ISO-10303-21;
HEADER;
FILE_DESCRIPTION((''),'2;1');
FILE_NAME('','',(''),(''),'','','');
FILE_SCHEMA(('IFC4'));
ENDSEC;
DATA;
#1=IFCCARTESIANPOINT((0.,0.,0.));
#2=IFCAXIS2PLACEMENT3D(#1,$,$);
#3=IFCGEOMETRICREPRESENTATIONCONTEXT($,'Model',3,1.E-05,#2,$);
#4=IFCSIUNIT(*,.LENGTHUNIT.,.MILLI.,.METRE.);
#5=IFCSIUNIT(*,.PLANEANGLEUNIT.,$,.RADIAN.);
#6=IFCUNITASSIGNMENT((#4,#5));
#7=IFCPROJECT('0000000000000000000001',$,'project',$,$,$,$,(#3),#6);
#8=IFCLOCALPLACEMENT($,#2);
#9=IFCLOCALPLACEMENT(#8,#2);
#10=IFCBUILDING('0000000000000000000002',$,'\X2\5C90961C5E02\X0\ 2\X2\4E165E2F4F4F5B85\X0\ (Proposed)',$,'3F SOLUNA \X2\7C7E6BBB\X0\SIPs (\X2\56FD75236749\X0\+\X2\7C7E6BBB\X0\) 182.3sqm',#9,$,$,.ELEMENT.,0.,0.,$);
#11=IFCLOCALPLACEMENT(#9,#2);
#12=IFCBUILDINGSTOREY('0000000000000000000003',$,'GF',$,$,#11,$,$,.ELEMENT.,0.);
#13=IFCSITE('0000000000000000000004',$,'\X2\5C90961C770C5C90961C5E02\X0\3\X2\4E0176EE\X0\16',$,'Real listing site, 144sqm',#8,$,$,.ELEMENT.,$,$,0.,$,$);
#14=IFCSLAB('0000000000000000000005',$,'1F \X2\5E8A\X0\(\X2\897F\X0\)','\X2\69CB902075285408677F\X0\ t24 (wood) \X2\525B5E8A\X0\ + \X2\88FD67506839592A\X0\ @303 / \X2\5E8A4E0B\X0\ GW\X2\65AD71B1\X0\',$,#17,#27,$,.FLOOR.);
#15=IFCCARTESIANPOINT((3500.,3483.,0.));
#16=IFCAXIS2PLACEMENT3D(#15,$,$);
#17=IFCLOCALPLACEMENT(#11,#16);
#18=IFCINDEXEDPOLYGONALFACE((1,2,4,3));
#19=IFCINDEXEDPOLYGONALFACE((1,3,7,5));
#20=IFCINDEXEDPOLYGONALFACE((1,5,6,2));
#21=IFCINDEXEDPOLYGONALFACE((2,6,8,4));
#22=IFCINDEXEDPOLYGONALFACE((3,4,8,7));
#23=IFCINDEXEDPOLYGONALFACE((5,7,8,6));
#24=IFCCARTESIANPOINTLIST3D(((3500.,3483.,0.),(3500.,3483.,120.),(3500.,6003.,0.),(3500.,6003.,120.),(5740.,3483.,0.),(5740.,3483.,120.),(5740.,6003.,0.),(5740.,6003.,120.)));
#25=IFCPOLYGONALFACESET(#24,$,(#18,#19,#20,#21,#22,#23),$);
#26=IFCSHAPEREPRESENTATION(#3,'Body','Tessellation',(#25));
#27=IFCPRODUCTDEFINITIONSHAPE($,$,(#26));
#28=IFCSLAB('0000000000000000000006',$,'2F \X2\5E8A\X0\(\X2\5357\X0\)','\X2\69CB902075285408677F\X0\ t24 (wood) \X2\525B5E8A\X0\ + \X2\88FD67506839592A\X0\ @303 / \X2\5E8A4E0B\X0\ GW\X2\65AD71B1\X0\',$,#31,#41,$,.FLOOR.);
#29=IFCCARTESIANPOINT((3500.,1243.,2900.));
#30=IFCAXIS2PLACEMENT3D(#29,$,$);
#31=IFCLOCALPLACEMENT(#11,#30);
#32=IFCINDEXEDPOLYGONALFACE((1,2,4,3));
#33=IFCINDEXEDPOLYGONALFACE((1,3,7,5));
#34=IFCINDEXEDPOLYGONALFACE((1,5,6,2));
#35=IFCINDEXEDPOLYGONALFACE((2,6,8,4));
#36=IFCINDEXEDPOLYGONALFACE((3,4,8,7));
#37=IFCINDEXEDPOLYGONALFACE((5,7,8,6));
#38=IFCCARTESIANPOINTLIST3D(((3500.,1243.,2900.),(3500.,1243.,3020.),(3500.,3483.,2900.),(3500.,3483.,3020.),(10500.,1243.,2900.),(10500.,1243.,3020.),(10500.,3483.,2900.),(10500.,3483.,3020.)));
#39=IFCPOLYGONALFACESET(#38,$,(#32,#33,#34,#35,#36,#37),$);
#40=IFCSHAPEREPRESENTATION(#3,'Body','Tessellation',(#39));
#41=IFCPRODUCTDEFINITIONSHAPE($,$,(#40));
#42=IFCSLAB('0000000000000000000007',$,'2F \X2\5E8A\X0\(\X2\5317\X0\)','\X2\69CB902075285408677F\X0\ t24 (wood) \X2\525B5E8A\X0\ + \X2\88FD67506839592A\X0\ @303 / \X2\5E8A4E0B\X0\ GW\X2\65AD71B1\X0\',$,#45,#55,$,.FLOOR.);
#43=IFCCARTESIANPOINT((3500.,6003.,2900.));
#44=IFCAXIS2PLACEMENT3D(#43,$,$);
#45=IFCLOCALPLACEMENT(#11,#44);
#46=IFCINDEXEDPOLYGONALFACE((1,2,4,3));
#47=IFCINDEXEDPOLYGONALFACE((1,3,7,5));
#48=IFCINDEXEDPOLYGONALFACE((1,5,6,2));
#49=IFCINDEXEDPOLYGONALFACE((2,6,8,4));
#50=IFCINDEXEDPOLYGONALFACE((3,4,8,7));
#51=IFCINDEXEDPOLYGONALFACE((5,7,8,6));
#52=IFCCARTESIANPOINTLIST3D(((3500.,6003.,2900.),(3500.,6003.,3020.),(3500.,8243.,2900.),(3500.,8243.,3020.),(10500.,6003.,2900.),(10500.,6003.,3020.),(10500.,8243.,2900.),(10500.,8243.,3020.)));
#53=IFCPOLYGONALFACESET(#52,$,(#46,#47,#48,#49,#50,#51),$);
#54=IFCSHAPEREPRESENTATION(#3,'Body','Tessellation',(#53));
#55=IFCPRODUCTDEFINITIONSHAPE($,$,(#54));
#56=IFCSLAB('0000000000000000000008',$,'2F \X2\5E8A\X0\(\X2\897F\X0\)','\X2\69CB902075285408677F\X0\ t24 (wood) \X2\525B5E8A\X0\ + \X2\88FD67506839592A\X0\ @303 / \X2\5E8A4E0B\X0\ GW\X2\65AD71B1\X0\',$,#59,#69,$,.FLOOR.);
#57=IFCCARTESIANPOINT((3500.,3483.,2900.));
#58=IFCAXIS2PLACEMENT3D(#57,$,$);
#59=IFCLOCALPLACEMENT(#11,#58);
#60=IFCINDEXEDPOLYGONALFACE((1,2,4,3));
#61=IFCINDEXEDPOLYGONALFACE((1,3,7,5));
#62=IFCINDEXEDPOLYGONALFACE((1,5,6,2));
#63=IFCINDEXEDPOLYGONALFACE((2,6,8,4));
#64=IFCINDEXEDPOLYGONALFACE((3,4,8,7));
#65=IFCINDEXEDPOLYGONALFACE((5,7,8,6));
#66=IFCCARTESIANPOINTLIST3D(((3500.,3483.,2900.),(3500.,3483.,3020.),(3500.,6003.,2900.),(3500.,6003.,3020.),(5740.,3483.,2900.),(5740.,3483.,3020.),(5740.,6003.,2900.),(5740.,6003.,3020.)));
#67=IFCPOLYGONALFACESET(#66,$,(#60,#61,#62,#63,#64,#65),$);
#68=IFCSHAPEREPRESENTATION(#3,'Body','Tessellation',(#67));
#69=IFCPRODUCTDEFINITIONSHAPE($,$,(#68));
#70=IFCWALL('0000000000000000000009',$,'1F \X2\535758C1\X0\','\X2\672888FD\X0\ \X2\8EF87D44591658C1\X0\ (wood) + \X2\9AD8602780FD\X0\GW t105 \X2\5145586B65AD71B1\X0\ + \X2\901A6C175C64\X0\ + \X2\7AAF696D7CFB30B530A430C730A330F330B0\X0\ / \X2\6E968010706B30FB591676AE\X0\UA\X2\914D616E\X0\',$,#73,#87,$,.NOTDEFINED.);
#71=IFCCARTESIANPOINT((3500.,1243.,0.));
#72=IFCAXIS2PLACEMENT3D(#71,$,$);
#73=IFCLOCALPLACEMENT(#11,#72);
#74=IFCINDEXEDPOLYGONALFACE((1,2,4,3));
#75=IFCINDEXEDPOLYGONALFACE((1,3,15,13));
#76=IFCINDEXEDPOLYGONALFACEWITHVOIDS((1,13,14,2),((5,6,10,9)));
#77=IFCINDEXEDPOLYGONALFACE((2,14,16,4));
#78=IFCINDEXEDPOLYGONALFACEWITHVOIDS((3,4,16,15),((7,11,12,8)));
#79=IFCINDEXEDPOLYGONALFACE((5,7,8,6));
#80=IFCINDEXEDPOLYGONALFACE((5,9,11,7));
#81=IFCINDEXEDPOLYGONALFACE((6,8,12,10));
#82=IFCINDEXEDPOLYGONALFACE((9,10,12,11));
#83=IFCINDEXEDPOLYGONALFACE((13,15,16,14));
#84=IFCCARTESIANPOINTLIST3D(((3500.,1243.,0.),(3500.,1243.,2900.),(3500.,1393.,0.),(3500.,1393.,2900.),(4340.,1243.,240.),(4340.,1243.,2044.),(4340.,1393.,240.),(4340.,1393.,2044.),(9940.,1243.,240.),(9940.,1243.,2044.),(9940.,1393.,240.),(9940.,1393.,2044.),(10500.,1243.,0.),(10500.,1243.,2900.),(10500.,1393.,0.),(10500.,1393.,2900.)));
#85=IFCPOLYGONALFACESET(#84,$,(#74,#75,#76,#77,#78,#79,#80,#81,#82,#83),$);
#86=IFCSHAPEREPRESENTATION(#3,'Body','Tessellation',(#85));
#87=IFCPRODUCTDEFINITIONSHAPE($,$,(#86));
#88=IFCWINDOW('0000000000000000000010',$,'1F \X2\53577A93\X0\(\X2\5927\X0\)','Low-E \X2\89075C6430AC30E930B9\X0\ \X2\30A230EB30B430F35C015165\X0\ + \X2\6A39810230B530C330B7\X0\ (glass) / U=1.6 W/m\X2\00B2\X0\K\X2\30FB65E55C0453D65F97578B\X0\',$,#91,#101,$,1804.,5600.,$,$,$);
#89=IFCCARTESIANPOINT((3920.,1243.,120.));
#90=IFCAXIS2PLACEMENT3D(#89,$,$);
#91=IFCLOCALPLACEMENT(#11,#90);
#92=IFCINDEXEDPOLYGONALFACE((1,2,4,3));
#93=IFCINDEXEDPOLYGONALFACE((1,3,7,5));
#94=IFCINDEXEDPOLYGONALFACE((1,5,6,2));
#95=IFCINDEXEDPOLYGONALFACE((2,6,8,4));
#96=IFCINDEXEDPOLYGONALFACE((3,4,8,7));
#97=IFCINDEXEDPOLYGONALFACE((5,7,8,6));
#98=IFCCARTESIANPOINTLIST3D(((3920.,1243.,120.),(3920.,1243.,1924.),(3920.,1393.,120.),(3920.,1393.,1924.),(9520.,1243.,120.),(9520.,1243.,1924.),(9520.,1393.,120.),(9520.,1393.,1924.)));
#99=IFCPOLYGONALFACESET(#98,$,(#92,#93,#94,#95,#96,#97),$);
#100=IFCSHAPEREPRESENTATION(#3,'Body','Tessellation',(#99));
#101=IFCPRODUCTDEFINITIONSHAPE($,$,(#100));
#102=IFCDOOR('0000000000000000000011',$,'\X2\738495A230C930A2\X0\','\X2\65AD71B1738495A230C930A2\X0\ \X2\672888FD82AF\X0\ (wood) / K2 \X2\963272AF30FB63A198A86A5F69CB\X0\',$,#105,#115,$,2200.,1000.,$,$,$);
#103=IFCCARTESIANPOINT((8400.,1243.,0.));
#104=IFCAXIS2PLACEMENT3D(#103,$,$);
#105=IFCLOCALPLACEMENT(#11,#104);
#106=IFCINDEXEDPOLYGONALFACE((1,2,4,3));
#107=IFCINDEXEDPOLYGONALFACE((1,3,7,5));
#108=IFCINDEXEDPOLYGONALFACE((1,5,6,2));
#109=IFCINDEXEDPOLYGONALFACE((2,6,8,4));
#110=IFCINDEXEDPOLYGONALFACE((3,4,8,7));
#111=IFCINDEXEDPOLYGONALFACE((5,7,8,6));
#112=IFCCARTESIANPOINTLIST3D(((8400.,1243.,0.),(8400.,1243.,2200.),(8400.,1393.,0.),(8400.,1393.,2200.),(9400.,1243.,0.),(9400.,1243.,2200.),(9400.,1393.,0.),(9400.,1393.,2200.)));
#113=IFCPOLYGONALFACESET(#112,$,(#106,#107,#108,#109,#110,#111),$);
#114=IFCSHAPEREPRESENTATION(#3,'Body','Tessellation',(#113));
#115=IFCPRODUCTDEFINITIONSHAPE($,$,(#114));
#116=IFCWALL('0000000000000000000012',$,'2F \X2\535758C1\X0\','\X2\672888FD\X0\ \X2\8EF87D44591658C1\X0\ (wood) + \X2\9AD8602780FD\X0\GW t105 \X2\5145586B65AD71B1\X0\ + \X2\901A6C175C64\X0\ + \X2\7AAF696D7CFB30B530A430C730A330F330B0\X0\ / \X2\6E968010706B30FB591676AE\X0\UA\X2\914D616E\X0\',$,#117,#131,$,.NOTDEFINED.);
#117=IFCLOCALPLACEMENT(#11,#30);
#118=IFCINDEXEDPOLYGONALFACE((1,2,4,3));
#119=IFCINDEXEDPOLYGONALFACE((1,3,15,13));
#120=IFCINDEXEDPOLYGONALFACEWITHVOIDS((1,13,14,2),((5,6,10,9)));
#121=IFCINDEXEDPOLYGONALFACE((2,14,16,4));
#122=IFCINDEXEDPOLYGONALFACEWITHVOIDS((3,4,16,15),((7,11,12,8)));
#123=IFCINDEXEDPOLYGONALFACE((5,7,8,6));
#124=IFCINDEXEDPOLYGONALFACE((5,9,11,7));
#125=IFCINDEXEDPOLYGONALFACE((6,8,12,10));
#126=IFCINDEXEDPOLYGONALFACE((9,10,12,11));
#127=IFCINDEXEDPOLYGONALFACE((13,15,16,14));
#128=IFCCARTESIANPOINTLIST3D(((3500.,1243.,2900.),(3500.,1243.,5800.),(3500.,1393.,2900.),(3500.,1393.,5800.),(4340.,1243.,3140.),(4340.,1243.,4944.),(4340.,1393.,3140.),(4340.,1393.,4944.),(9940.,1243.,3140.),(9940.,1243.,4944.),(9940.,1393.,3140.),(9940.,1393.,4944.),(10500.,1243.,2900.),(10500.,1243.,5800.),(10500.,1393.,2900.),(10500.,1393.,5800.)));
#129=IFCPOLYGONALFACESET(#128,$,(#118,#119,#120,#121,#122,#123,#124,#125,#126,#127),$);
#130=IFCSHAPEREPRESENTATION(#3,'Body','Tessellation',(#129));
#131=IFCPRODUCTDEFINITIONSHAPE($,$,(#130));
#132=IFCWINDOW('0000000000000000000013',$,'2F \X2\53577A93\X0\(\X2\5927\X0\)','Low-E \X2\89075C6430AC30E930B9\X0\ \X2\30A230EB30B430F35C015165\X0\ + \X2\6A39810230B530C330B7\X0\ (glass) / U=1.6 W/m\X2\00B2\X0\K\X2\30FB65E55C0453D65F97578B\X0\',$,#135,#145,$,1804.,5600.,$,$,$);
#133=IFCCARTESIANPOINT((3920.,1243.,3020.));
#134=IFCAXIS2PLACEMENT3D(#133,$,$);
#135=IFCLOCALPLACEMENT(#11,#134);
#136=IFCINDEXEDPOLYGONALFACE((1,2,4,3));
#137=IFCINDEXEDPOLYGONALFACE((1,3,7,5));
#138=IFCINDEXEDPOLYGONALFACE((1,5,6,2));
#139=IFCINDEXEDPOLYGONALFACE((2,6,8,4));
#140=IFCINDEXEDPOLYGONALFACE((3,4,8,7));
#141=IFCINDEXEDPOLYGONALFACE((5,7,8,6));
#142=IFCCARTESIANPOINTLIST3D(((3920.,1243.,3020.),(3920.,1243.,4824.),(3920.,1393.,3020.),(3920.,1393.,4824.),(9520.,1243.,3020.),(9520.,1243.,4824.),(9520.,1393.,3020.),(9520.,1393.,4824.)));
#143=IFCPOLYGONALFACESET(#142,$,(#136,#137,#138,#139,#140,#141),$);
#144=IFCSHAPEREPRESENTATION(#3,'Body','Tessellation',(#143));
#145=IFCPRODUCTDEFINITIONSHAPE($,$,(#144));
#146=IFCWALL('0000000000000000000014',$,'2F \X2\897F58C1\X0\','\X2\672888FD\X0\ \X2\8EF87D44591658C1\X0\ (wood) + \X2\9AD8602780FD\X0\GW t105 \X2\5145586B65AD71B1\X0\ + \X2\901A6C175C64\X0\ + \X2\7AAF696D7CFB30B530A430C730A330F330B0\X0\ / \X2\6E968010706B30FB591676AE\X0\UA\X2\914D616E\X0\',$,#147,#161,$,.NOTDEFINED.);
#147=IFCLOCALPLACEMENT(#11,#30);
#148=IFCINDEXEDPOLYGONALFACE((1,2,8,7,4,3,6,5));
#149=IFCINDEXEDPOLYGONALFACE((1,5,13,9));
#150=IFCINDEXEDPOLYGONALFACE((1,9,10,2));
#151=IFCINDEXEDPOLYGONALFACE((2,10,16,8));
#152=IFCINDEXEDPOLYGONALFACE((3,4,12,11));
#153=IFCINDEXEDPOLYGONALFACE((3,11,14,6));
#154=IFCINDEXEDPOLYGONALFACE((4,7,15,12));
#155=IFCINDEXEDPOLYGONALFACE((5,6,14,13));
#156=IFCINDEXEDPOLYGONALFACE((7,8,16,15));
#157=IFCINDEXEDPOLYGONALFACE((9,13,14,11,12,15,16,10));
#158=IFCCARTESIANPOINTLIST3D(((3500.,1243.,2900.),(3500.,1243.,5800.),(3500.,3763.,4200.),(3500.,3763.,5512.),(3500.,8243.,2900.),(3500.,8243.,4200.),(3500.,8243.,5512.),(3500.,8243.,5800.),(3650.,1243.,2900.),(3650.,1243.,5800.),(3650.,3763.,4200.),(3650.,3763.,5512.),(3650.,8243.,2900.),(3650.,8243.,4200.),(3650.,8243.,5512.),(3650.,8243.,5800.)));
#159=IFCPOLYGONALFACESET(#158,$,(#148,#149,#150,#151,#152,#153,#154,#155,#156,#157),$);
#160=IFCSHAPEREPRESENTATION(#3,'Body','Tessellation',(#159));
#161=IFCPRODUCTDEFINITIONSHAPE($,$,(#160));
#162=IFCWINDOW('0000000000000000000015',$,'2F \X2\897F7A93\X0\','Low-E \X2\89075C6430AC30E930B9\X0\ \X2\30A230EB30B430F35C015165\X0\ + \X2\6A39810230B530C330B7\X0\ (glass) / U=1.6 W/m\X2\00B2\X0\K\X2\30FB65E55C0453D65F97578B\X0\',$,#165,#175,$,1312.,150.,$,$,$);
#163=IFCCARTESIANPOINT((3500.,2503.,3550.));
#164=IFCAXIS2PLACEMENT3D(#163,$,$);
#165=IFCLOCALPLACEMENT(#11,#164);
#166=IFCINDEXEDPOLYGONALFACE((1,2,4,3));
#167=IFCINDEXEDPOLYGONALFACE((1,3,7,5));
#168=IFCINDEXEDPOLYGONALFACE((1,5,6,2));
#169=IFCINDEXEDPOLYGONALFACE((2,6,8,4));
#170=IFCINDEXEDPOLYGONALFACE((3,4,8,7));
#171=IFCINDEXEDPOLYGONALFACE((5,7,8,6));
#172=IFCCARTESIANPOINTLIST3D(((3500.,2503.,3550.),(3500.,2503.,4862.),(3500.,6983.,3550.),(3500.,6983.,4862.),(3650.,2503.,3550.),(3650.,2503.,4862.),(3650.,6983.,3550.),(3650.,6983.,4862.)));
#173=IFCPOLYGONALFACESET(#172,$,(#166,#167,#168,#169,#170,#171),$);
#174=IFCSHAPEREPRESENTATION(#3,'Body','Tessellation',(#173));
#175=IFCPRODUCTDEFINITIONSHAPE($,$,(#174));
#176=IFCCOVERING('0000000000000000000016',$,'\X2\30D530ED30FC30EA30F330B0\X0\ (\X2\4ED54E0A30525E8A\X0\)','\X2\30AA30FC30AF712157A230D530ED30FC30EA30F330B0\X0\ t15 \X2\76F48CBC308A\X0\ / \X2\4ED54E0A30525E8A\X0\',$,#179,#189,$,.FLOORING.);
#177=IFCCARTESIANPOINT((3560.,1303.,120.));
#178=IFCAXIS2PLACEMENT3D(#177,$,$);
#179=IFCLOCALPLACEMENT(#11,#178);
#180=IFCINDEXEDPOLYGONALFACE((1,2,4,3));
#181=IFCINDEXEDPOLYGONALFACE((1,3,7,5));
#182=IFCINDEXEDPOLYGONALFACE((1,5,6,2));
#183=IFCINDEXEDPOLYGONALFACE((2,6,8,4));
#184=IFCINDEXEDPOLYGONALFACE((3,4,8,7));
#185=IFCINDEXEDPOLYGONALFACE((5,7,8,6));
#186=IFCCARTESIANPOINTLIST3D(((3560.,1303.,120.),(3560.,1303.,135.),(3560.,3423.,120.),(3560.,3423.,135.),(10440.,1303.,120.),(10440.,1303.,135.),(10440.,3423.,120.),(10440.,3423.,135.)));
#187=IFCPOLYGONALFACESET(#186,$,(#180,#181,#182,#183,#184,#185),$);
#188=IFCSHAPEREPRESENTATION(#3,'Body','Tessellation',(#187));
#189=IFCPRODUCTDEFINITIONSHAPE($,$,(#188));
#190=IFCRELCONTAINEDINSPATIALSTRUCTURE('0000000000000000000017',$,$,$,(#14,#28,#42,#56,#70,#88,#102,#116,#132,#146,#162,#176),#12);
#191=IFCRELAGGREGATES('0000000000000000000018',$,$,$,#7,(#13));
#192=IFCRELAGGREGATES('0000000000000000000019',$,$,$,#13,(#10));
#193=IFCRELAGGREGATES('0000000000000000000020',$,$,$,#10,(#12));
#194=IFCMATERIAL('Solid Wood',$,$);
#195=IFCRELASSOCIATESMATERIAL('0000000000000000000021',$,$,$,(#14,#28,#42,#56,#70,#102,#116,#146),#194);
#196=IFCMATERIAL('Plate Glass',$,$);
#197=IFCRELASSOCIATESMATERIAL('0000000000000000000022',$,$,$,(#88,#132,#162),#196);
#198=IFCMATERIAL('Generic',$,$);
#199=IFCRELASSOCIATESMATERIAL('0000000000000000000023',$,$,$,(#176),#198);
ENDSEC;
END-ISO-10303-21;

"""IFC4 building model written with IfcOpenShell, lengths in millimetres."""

from ifc_helpers import new_model, si_unit, frame, frame_2d, origin, place, context, project, spatial, rectangle, extrude, material, element, fill, save


model = new_model("IFC4")

# Units and contexts
model_context = context("Model", 3, precision=1e-05, world=origin())
ifc_project = project(units=[si_unit("LENGTHUNIT", "METRE", prefix="MILLI"), si_unit("PLANEANGLEUNIT", "RADIAN")], contexts=[model_context])

# Site, building, storey
site_placement = place(None, origin())
site = spatial("IfcSite", under=ifc_project, at=site_placement, Name="岐阜県岐阜市3丁目16", ObjectType="Real listing site, 144sqm", CompositionType="ELEMENT", RefElevation=0.0)
building_placement = place(site_placement, origin())
building = spatial("IfcBuilding", under=site, at=building_placement, Name="岐阜市 2世帯住宅 (Proposed)", ObjectType="3F SOLUNA 籾殻SIPs (国産杉+籾殻) 182.3sqm", CompositionType="ELEMENT", ElevationOfRefHeight=0.0, ElevationOfTerrain=0.0)
storey_placement = place(building_placement, origin())
storey = spatial("IfcBuildingStorey", under=building, at=storey_placement, Name="GF", CompositionType="ELEMENT", Elevation=0.0)

# Slabs
ifc_material_1 = material(Name="Solid Wood")
slab_1_placement = place(storey_placement, frame((3500.0, 3483.0, 0.0)))
element("IfcSlab", 1, at=slab_1_placement, inside=storey, material=ifc_material_1, Name="1F 床(西)", Description="構造用合板 t24 (wood) 剛床 + 製材根太 @303 / 床下 GW断熱", PredefinedType="FLOOR", context=model_context, shape_type="SweptSolid", body=[
    extrude(rectangle(XDim=2240.0, YDim=2520.0, at=frame_2d((1120.0, 1260.0))), frame((3500.0, 3483.0, 0.0)), (0.0, 0.0, 1.0), 120.0),
])
slab_2_placement = place(storey_placement, frame((3500.0, 1243.0, 2900.0)))
element("IfcSlab", 2, at=slab_2_placement, inside=storey, material=ifc_material_1, Name="2F 床(南)", Description="構造用合板 t24 (wood) 剛床 + 製材根太 @303 / 床下 GW断熱", PredefinedType="FLOOR", context=model_context, shape_type="SweptSolid", body=[
    extrude(rectangle(XDim=7000.0, YDim=2240.0, at=frame_2d((3500.0, 1120.0))), frame((3500.0, 1243.0, 2900.0)), (0.0, 0.0, 1.0), 120.0),
])
slab_3_placement = place(storey_placement, frame((3500.0, 6003.0, 2900.0)))
element("IfcSlab", 3, at=slab_3_placement, inside=storey, material=ifc_material_1, Name="2F 床(北)", Description="構造用合板 t24 (wood) 剛床 + 製材根太 @303 / 床下 GW断熱", PredefinedType="FLOOR", context=model_context, shape_type="SweptSolid", body=[
    extrude(rectangle(XDim=7000.0, YDim=2240.0, at=frame_2d((3500.0, 1120.0))), frame((3500.0, 6003.0, 2900.0)), (0.0, 0.0, 1.0), 120.0),
])
slab_4_placement = place(storey_placement, frame((3500.0, 3483.0, 2900.0)))
element("IfcSlab", 4, at=slab_4_placement, inside=storey, material=ifc_material_1, Name="2F 床(西)", Description="構造用合板 t24 (wood) 剛床 + 製材根太 @303 / 床下 GW断熱", PredefinedType="FLOOR", context=model_context, shape_type="SweptSolid", body=[
    extrude(rectangle(XDim=2240.0, YDim=2520.0, at=frame_2d((1120.0, 1260.0))), frame((3500.0, 3483.0, 2900.0)), (0.0, 0.0, 1.0), 120.0),
])

# Wall, openings, window, door
wall_1_placement = place(storey_placement, frame((3500.0, 1243.0, 0.0)))
wall_1 = element("IfcWall", 5, at=wall_1_placement, inside=storey, material=ifc_material_1, Name="1F 南壁", Description="木製 軸組外壁 (wood) + 高性能GW t105 充填断熱 + 通気層 + 窯業系サイディング / 準耐火・外皮UA配慮", PredefinedType="NOTDEFINED", context=model_context, shape_type="SweptSolid", body=[
    extrude(rectangle(XDim=7000.0, YDim=150.0, at=frame_2d((3500.0, 75.0))), frame((3500.0, 1243.0, 0.0)), (0.0, 0.0, 1.0), 2900.0),
])
opening_1_placement = place(storey_placement, frame((3920.0, 1243.0, 120.0)))
opening_1 = element("IfcOpeningElement", 6, at=opening_1_placement, cuts=wall_1, PredefinedType="NOTDEFINED", context=model_context, shape_type="SweptSolid", body=[
    extrude(rectangle(XDim=5600.0, YDim=150.0, at=frame_2d((2800.0, 75.0))), frame((3920.0, 1243.0, 120.0)), (0.0, 0.0, 1.0), 1804.0),
])
opening_2_placement = place(storey_placement, frame((8400.0, 1243.0, 0.0)))
opening_2 = element("IfcOpeningElement", 7, at=opening_2_placement, cuts=wall_1, PredefinedType="NOTDEFINED", context=model_context, shape_type="SweptSolid", body=[
    extrude(rectangle(XDim=1000.0, YDim=150.0, at=frame_2d((500.0, 75.0))), frame((8400.0, 1243.0, 0.0)), (0.0, 0.0, 1.0), 2200.0),
])
ifc_material_2 = material(Name="Plate Glass")
window_1_placement = place(storey_placement, frame((3920.0, 1243.0, 120.0)))
window_1 = element("IfcWindow", 8, at=window_1_placement, inside=storey, material=ifc_material_2, Name="1F 南窓(大)", Description="Low-E 複層ガラス アルゴン封入 + 樹脂サッシ (glass) / U=1.6 W/m²K・日射取得型", OverallHeight=1804.0, OverallWidth=5600.0, context=model_context, shape_type="SweptSolid", body=[
    extrude(rectangle(XDim=5600.0, YDim=150.0, at=frame_2d((2800.0, 75.0))), frame((3920.0, 1243.0, 120.0)), (0.0, 0.0, 1.0), 1804.0),
])
fill(opening_1, window_1)
door_placement = place(storey_placement, frame((8400.0, 1243.0, 0.0)))
door = element("IfcDoor", 9, at=door_placement, inside=storey, material=ifc_material_1, Name="玄関ドア", Description="断熱玄関ドア 木製芯 (wood) / K2 防犯・採風機構", OverallHeight=2200.0, OverallWidth=1000.0, context=model_context, shape_type="SweptSolid", body=[
    extrude(rectangle(XDim=1000.0, YDim=150.0, at=frame_2d((500.0, 75.0))), frame((8400.0, 1243.0, 0.0)), (0.0, 0.0, 1.0), 2200.0),
])
fill(opening_2, door)

# Wall, opening, window
wall_2_placement = place(storey_placement, frame((3500.0, 1243.0, 2900.0)))
wall_2 = element("IfcWall", 10, at=wall_2_placement, inside=storey, material=ifc_material_1, Name="2F 南壁", Description="木製 軸組外壁 (wood) + 高性能GW t105 充填断熱 + 通気層 + 窯業系サイディング / 準耐火・外皮UA配慮", PredefinedType="NOTDEFINED", context=model_context, shape_type="SweptSolid", body=[
    extrude(rectangle(XDim=7000.0, YDim=150.0, at=frame_2d((3500.0, 75.0))), frame((3500.0, 1243.0, 2900.0)), (0.0, 0.0, 1.0), 2900.0),
])
opening_3_placement = place(storey_placement, frame((3920.0, 1243.0, 3020.0)))
opening_3 = element("IfcOpeningElement", 11, at=opening_3_placement, cuts=wall_2, PredefinedType="NOTDEFINED", context=model_context, shape_type="SweptSolid", body=[
    extrude(rectangle(XDim=5600.0, YDim=150.0, at=frame_2d((2800.0, 75.0))), frame((3920.0, 1243.0, 3020.0)), (0.0, 0.0, 1.0), 1804.0),
])
window_2_placement = place(storey_placement, frame((3920.0, 1243.0, 3020.0)))
window_2 = element("IfcWindow", 12, at=window_2_placement, inside=storey, material=ifc_material_2, Name="2F 南窓(大)", Description="Low-E 複層ガラス アルゴン封入 + 樹脂サッシ (glass) / U=1.6 W/m²K・日射取得型", OverallHeight=1804.0, OverallWidth=5600.0, context=model_context, shape_type="SweptSolid", body=[
    extrude(rectangle(XDim=5600.0, YDim=150.0, at=frame_2d((2800.0, 75.0))), frame((3920.0, 1243.0, 3020.0)), (0.0, 0.0, 1.0), 1804.0),
])
fill(opening_3, window_2)

# Wall, opening, window
wall_3_placement = place(storey_placement, frame((3500.0, 1243.0, 2900.0)))
wall_3 = element("IfcWall", 13, at=wall_3_placement, inside=storey, material=ifc_material_1, Name="2F 西壁", Description="木製 軸組外壁 (wood) + 高性能GW t105 充填断熱 + 通気層 + 窯業系サイディング / 準耐火・外皮UA配慮", PredefinedType="NOTDEFINED", context=model_context, shape_type="SweptSolid", body=[
    extrude(rectangle(XDim=150.0, YDim=7000.0, at=frame_2d((75.0, 3500.0))), frame((3500.0, 1243.0, 2900.0)), (0.0, 0.0, 1.0), 2900.0),
])
opening_4_placement = place(storey_placement, frame((3500.0, 2503.0, 3550.0)))
opening_4 = element("IfcOpeningElement", 14, at=opening_4_placement, cuts=wall_3, PredefinedType="NOTDEFINED", context=model_context, shape_type="SweptSolid", body=[
    extrude(rectangle(XDim=150.0, YDim=4480.0, at=frame_2d((75.0, 2240.0))), frame((3500.0, 2503.0, 3550.0)), (0.0, 0.0, 1.0), 1312.0),
])
window_3_placement = place(storey_placement, frame((3500.0, 2503.0, 3550.0)))
window_3 = element("IfcWindow", 15, at=window_3_placement, inside=storey, material=ifc_material_2, Name="2F 西窓", Description="Low-E 複層ガラス アルゴン封入 + 樹脂サッシ (glass) / U=1.6 W/m²K・日射取得型", OverallHeight=1312.0, OverallWidth=150.0, context=model_context, shape_type="SweptSolid", body=[
    extrude(rectangle(XDim=150.0, YDim=4480.0, at=frame_2d((75.0, 2240.0))), frame((3500.0, 2503.0, 3550.0)), (0.0, 0.0, 1.0), 1312.0),
])
fill(opening_4, window_3)

# Covering
ifc_material_3 = material(Name="Generic")
covering_1_placement = place(storey_placement, frame((3560.0, 1303.0, 120.0)))
element("IfcCovering", 16, at=covering_1_placement, inside=storey, material=ifc_material_3, Name="フローリング (仕上げ床)", Description="オーク無垢フローリング t15 直貼り / 仕上げ床", PredefinedType="FLOORING", context=model_context, shape_type="SweptSolid", body=[
    extrude(rectangle(XDim=6880.0, YDim=2120.0, at=frame_2d((3440.0, 1060.0))), frame((3560.0, 1303.0, 120.0)), (0.0, 0.0, 1.0), 15.0),
])

save(model, "model.ifc")
